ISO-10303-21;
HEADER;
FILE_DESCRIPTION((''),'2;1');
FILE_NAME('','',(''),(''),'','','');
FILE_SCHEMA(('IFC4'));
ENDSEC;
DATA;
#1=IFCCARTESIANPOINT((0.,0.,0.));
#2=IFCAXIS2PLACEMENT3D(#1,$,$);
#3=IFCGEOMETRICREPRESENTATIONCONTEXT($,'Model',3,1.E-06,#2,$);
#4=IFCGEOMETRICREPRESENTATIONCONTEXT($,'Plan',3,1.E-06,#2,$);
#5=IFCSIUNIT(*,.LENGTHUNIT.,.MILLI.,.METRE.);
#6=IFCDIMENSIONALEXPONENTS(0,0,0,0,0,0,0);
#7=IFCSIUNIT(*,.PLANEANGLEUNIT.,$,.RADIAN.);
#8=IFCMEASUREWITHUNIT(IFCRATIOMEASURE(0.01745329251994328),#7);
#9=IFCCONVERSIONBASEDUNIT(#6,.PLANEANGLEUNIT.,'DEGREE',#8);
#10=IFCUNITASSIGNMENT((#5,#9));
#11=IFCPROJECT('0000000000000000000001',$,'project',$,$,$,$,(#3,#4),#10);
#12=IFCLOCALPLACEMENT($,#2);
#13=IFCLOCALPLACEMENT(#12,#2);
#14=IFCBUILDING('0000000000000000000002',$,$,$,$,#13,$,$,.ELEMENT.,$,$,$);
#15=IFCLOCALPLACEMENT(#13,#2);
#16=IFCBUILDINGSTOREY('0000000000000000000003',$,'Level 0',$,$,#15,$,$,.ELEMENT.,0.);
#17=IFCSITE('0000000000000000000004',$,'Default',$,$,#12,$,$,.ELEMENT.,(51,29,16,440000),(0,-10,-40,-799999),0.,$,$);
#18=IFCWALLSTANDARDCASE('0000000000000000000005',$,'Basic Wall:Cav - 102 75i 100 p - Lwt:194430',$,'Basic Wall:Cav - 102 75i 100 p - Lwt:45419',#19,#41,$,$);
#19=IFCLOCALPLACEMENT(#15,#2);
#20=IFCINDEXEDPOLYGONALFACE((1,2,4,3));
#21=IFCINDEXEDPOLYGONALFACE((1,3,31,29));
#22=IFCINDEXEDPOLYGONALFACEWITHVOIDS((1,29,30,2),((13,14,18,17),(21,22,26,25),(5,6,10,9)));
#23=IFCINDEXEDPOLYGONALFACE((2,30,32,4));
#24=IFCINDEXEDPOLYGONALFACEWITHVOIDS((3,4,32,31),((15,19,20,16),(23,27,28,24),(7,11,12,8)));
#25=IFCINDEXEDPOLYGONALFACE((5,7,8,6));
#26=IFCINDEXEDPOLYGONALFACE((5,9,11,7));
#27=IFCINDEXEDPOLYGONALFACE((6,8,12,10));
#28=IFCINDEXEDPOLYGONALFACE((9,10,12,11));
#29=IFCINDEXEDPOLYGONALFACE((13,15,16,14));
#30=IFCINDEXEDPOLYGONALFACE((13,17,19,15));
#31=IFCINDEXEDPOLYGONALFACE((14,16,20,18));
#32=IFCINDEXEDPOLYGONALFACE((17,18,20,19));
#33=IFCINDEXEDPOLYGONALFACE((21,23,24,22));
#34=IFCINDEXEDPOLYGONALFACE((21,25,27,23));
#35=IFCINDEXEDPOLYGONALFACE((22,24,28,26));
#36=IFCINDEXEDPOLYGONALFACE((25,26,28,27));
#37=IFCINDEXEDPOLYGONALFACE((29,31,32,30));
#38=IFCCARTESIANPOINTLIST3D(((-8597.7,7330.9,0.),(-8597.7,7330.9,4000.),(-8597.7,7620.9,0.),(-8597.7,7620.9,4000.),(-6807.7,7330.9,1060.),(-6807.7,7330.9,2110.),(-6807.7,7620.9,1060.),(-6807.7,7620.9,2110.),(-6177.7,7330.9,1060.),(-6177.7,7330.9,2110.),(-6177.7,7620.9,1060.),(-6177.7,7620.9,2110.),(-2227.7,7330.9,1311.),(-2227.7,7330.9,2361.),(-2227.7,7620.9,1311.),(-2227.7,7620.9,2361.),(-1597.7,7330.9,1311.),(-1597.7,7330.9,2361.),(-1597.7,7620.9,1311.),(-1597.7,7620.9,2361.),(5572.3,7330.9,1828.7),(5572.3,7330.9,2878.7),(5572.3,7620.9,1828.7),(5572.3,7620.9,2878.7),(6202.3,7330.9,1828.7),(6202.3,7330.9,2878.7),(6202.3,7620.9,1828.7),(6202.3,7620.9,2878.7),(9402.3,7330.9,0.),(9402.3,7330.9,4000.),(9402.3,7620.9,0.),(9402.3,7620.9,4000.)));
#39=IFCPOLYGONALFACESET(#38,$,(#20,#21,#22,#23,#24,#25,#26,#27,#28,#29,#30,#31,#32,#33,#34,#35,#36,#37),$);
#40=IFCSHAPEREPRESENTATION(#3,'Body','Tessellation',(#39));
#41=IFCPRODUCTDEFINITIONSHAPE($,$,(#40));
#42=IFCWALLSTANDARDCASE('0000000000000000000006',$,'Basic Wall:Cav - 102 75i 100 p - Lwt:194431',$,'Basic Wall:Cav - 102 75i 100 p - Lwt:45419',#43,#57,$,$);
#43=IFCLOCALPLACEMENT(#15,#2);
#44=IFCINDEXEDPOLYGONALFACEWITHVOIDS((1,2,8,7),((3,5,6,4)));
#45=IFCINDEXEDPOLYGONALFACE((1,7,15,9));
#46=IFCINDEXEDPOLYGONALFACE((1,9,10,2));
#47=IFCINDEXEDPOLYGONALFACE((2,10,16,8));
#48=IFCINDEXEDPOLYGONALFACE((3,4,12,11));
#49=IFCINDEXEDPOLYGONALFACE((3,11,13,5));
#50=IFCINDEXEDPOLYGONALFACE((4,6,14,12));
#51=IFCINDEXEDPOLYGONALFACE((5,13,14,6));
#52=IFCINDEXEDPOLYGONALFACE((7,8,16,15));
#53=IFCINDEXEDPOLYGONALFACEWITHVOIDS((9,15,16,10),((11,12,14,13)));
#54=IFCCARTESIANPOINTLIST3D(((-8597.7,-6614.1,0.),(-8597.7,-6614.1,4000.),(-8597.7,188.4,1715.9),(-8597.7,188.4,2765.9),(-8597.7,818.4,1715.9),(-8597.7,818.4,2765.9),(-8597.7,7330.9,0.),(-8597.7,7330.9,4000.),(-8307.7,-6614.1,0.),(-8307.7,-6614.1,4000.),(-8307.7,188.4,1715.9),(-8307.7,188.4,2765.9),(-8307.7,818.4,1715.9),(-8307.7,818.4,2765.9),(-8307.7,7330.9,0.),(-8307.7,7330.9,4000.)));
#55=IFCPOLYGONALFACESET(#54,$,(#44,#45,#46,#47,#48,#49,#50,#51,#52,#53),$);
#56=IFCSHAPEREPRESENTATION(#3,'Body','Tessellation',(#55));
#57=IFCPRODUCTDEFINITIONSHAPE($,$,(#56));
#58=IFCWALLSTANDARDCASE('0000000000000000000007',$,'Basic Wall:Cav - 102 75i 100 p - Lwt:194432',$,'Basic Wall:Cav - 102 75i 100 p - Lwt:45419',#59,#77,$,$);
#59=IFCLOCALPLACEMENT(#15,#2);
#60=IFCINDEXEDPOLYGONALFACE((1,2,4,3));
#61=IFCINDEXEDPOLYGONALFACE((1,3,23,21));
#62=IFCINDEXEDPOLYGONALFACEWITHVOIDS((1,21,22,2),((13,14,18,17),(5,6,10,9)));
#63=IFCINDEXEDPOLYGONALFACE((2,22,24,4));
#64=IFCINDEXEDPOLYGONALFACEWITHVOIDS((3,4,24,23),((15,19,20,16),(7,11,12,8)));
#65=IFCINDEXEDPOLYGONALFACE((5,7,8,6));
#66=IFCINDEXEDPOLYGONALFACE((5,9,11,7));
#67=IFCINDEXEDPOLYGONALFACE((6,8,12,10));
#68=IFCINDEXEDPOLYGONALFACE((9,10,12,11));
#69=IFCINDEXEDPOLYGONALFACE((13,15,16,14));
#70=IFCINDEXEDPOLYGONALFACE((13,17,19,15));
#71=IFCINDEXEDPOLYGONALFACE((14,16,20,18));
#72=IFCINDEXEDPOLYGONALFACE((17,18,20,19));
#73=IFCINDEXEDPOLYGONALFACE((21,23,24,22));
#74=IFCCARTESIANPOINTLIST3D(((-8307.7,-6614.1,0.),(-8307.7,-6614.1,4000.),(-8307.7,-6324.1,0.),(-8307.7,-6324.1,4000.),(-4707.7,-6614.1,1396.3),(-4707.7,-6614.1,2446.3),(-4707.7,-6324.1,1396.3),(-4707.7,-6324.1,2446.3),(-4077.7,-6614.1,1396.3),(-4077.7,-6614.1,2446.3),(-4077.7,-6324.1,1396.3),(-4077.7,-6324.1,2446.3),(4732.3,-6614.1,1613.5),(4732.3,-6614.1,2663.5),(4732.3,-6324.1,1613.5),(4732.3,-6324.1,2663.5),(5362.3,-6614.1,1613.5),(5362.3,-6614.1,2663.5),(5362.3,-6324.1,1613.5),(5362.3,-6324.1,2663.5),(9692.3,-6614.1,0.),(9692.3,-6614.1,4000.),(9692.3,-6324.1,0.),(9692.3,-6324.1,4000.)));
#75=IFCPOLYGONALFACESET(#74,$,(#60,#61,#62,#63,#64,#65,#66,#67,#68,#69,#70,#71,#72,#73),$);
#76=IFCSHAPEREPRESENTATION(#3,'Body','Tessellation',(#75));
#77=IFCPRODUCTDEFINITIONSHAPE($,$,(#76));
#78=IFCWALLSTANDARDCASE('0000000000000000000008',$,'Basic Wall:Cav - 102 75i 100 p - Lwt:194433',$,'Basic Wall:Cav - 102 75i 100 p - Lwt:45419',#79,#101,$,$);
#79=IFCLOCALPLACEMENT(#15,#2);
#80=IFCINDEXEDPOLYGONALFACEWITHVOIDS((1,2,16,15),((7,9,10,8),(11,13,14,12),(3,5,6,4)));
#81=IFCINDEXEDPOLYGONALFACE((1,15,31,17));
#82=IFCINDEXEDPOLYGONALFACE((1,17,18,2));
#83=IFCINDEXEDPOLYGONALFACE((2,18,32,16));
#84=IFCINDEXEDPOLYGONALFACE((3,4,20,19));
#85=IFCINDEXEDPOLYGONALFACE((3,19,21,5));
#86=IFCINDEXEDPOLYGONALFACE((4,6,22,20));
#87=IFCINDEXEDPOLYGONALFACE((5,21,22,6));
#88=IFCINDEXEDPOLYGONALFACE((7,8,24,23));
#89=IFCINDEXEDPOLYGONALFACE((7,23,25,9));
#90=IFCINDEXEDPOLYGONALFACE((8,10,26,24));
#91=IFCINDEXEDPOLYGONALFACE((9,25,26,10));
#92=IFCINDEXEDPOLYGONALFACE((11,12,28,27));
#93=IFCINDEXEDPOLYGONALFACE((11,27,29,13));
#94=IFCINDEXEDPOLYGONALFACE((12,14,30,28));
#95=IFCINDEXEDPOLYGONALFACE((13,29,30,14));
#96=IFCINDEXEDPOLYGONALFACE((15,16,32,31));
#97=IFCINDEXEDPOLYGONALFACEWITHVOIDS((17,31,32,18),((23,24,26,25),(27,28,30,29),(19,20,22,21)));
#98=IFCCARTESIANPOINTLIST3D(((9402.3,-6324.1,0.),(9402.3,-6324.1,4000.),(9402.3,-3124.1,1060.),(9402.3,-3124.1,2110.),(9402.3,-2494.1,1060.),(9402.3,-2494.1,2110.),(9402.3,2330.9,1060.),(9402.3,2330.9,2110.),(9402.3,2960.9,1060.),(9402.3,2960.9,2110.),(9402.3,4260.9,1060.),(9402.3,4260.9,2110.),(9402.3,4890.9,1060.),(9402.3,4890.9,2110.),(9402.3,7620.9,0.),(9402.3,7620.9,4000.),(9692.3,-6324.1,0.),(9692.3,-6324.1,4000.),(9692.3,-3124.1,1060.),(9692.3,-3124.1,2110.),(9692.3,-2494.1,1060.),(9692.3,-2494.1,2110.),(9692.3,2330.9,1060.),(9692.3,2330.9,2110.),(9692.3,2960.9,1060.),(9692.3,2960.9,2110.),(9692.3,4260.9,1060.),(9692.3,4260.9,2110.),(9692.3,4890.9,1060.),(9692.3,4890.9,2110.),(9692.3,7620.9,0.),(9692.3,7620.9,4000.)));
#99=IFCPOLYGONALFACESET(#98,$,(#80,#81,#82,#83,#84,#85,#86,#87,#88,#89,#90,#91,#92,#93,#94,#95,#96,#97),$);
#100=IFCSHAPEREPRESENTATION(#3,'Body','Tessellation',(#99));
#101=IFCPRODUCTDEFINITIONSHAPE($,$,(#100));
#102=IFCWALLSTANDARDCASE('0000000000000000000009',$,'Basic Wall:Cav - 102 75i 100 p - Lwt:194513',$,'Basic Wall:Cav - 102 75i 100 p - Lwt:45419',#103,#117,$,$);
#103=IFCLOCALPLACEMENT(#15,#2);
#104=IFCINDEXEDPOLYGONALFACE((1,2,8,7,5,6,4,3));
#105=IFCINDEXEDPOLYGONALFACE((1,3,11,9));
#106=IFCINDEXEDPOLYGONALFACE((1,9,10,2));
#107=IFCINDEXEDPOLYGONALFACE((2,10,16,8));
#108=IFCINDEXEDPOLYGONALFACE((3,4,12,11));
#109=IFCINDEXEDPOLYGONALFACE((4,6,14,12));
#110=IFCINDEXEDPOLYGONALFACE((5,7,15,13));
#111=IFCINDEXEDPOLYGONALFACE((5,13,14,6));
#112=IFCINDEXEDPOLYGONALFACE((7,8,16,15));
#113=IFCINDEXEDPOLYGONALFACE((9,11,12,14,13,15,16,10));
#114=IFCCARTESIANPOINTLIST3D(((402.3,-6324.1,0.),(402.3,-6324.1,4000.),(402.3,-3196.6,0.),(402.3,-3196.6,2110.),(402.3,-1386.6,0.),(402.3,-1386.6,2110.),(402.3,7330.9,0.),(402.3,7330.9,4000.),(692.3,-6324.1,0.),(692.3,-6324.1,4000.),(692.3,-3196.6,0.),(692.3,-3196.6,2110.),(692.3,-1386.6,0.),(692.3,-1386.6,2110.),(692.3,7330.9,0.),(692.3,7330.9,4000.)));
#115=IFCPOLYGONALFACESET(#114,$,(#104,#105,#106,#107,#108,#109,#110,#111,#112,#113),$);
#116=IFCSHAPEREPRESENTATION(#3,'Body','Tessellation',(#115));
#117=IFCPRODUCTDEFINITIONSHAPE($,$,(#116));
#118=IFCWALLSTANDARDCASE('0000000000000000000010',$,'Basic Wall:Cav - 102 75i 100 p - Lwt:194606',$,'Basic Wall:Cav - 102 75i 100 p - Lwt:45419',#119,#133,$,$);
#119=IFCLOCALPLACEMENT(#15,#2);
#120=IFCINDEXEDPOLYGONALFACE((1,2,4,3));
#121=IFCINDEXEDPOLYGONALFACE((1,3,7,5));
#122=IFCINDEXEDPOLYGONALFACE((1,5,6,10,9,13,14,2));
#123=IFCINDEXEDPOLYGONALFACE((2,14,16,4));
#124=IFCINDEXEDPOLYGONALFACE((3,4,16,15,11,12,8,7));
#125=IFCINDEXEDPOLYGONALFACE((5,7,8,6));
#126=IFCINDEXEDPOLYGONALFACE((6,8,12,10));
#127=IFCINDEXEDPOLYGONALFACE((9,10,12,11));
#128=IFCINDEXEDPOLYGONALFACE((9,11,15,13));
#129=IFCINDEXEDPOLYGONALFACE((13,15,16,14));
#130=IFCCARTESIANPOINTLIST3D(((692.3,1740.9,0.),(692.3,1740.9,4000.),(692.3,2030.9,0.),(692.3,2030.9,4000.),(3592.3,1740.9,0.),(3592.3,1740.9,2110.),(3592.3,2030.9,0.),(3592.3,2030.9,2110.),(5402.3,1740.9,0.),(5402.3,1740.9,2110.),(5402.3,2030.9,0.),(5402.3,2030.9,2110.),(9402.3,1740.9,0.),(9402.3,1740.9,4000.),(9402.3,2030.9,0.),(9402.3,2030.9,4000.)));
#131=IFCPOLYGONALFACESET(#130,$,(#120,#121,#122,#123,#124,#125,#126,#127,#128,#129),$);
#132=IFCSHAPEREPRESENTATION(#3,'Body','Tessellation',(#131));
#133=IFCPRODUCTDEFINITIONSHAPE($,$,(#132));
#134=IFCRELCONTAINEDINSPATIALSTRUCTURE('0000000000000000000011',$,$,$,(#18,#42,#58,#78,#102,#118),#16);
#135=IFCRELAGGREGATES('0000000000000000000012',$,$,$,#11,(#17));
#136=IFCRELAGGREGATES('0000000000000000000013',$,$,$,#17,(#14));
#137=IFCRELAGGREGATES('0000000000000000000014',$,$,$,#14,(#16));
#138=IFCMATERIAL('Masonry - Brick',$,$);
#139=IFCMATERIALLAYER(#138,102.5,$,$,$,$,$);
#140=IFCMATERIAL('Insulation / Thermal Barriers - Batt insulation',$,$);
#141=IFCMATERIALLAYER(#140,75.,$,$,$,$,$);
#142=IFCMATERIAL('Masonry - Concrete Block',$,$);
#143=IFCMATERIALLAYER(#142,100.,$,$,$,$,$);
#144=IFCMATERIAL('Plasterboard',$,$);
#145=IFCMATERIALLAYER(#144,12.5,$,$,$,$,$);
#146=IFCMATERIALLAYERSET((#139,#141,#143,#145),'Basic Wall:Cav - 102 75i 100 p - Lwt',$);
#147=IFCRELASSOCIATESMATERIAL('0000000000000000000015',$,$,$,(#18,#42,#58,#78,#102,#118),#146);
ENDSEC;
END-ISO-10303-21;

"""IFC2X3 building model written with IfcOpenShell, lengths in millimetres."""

from ifc_helpers import new_model, entity, si_unit, converted_unit, frame, frame_2d, origin, place, context, project, spatial, rectangle, extrude, material, layer, layer_set, layer_usage, element, save


model = new_model("IFC2X3")

# Units and contexts
model_context = context("Model", 3, precision=1e-06, world=origin())
plan_context = context("Plan", 3, precision=1e-06, world=origin())
ifc_project = project(units=[si_unit("LENGTHUNIT", "METRE", prefix="MILLI"), converted_unit("PLANEANGLEUNIT", "DEGREE", entity("IfcRatioMeasure", 0.01745329251994328), si_unit("PLANEANGLEUNIT", "RADIAN"), dimensions=[0, 0, 0, 0, 0, 0, 0])], contexts=[model_context, plan_context])

# Site, building, storey
site_placement = place(None, origin())
site = spatial("IfcSite", under=ifc_project, at=site_placement, Name="Default", CompositionType="ELEMENT", RefLatitude=(51, 29, 16, 440000), RefLongitude=(0, -10, -40, -799999), RefElevation=0.0)
building_placement = place(site_placement, origin())
building = spatial("IfcBuilding", under=site, at=building_placement, CompositionType="ELEMENT")
storey_placement = place(building_placement, origin())
storey = spatial("IfcBuildingStorey", under=building, at=storey_placement, Name="Level 0", CompositionType="ELEMENT", Elevation=0.0)

# Wall, openings
ifc_material_1 = material(Name="Masonry - Brick")
ifc_layer_1 = layer(ifc_material_1, 102.5)
ifc_material_2 = material(Name="Insulation / Thermal Barriers - Batt insulation")
ifc_layer_2 = layer(ifc_material_2, 75.0)
ifc_material_3 = material(Name="Masonry - Concrete Block")
ifc_layer_3 = layer(ifc_material_3, 100.0)
ifc_material_4 = material(Name="Plasterboard")
ifc_layer_4 = layer(ifc_material_4, 12.5)
ifc_layer_set = layer_set([ifc_layer_1, ifc_layer_2, ifc_layer_3, ifc_layer_4], Name="Basic Wall:Cav - 102 75i 100 p - Lwt")
ifc_layer_usage_1 = layer_usage(ifc_layer_set, "AXIS2", "NEGATIVE", 145.0)
wall_1_placement = place(storey_placement, frame((-8597.7, 7475.9, 0.0)))
wall_1 = element("IfcWallStandardCase", 1, at=wall_1_placement, inside=storey, material=ifc_layer_usage_1, Name="Basic Wall:Cav - 102 75i 100 p - Lwt:194430", ObjectType="Basic Wall:Cav - 102 75i 100 p - Lwt:45419", context=model_context, shape_type="SweptSolid", body=[
    extrude(rectangle(XDim=18000.0, YDim=290.0, at=frame_2d((9000.0, 0.0), x_axis=(-1.0, 0.0))), origin(), (0.0, 0.0, 1.0), 4000.0),
])
opening_1_placement = place(wall_1_placement, frame((14170.0, -145.0, 1828.7)))
element("IfcOpeningElement", 2, at=opening_1_placement, cuts=wall_1, ObjectType="Opening", context=model_context, shape_type="SweptSolid", body=[
    extrude(rectangle(XDim=1050.0, YDim=630.0, at=frame_2d((525.0, 315.0), x_axis=(-1.0, 0.0))), frame((0.0, 0.0, 0.0), z_axis=(0.0, 1.0, 0.0), x_axis=(0.0, 0.0, 1.0)), (0.0, 0.0, 1.0), 290.0),
])
opening_2_placement = place(wall_1_placement, frame((6370.0, -145.0, 1311.0)))
element("IfcOpeningElement", 3, at=opening_2_placement, cuts=wall_1, ObjectType="Opening", context=model_context, shape_type="SweptSolid", body=[
    extrude(rectangle(XDim=1050.0, YDim=630.0, at=frame_2d((525.0, 315.0), x_axis=(-1.0, 0.0))), frame((0.0, 0.0, 0.0), z_axis=(0.0, 1.0, 0.0), x_axis=(0.0, 0.0, 1.0)), (0.0, 0.0, 1.0), 290.0),
])
opening_3_placement = place(wall_1_placement, frame((1790.0, -145.0, 1060.0)))
element("IfcOpeningElement", 4, at=opening_3_placement, cuts=wall_1, ObjectType="Opening", context=model_context, shape_type="SweptSolid", body=[
    extrude(rectangle(XDim=1050.0, YDim=630.0, at=frame_2d((525.0, 315.0), x_axis=(-1.0, 0.0))), frame((0.0, 0.0, 0.0), z_axis=(0.0, 1.0, 0.0), x_axis=(0.0, 0.0, 1.0)), (0.0, 0.0, 1.0), 290.0),
])

# Wall, opening
ifc_layer_usage_2 = layer_usage(ifc_layer_set, "AXIS2", "NEGATIVE", 145.0)
wall_2_placement = place(storey_placement, frame((-8452.7, -6614.1, 0.0), z_axis=(0.0, 0.0, 1.0), x_axis=(0.0, 1.0, 0.0)))
wall_2 = element("IfcWallStandardCase", 5, at=wall_2_placement, inside=storey, material=ifc_layer_usage_2, Name="Basic Wall:Cav - 102 75i 100 p - Lwt:194431", ObjectType="Basic Wall:Cav - 102 75i 100 p - Lwt:45419", context=model_context, shape_type="SweptSolid", body=[
    extrude(rectangle(XDim=13945.0, YDim=290.0, at=frame_2d((6972.5, 0.0), x_axis=(-1.0, 0.0))), origin(), (0.0, 0.0, 1.0), 4000.0),
])
opening_4_placement = place(wall_2_placement, frame((7432.5, 145.0, 1715.9)))
element("IfcOpeningElement", 6, at=opening_4_placement, cuts=wall_2, ObjectType="Opening", context=model_context, shape_type="SweptSolid", body=[
    extrude(rectangle(XDim=1050.0, YDim=630.0, at=frame_2d((525.0, 315.0), x_axis=(-1.0, 0.0))), frame((0.0, 0.0, 0.0), z_axis=(0.0, -1.0, 0.0), x_axis=(0.0, 0.0, 1.0)), (0.0, 0.0, 1.0), 290.0),
])

# Walls, openings
ifc_layer_usage_3 = layer_usage(ifc_layer_set, "AXIS2", "NEGATIVE", 145.0)
wall_3_placement = place(storey_placement, frame((9692.3, -6469.1, 0.0), z_axis=(0.0, 0.0, 1.0), x_axis=(-1.0, 0.0, 0.0)))
wall_3 = element("IfcWallStandardCase", 7, at=wall_3_placement, inside=storey, material=ifc_layer_usage_3, Name="Basic Wall:Cav - 102 75i 100 p - Lwt:194432", ObjectType="Basic Wall:Cav - 102 75i 100 p - Lwt:45419", context=model_context, shape_type="SweptSolid", body=[
    extrude(rectangle(XDim=18000.0, YDim=290.0, at=frame_2d((9000.0, 0.0), x_axis=(-1.0, 0.0))), origin(), (0.0, 0.0, 1.0), 4000.0),
])
opening_5_placement = place(wall_3_placement, frame((14400.0, 145.0, 1396.3)))
element("IfcOpeningElement", 8, at=opening_5_placement, cuts=wall_3, ObjectType="Opening", context=model_context, shape_type="SweptSolid", body=[
    extrude(rectangle(XDim=1050.0, YDim=630.0, at=frame_2d((525.0, 315.0), x_axis=(-1.0, 0.0))), frame((0.0, 0.0, 0.0), z_axis=(0.0, -1.0, 0.0), x_axis=(0.0, 0.0, 1.0)), (0.0, 0.0, 1.0), 290.0),
])
opening_6_placement = place(wall_3_placement, frame((4960.0, 145.0, 1613.5)))
element("IfcOpeningElement", 9, at=opening_6_placement, cuts=wall_3, ObjectType="Opening", context=model_context, shape_type="SweptSolid", body=[
    extrude(rectangle(XDim=1050.0, YDim=630.0, at=frame_2d((525.0, 315.0), x_axis=(-1.0, 0.0))), frame((0.0, 0.0, 0.0), z_axis=(0.0, -1.0, 0.0), x_axis=(0.0, 0.0, 1.0)), (0.0, 0.0, 1.0), 290.0),
])
ifc_layer_usage_4 = layer_usage(ifc_layer_set, "AXIS2", "NEGATIVE", 145.0)
wall_4_placement = place(storey_placement, frame((9547.3, 7620.9, 0.0), z_axis=(0.0, 0.0, 1.0), x_axis=(0.0, -1.0, 0.0)))
wall_4 = element("IfcWallStandardCase", 10, at=wall_4_placement, inside=storey, material=ifc_layer_usage_4, Name="Basic Wall:Cav - 102 75i 100 p - Lwt:194433", ObjectType="Basic Wall:Cav - 102 75i 100 p - Lwt:45419", context=model_context, shape_type="SweptSolid", body=[
    extrude(rectangle(XDim=13945.0, YDim=290.0, at=frame_2d((6972.5, 0.0), x_axis=(-1.0, 0.0))), origin(), (0.0, 0.0, 1.0), 4000.0),
])
opening_7_placement = place(wall_4_placement, frame((10115.0, -145.0, 1060.0)))
element("IfcOpeningElement", 11, at=opening_7_placement, cuts=wall_4, ObjectType="Opening", context=model_context, shape_type="SweptSolid", body=[
    extrude(rectangle(XDim=1050.0, YDim=630.0, at=frame_2d((525.0, 315.0), x_axis=(-1.0, 0.0))), frame((0.0, 0.0, 0.0), z_axis=(0.0, 1.0, 0.0), x_axis=(0.0, 0.0, 1.0)), (0.0, 0.0, 1.0), 290.0),
])
opening_8_placement = place(wall_4_placement, frame((4660.0, -145.0, 1060.0)))
element("IfcOpeningElement", 12, at=opening_8_placement, cuts=wall_4, ObjectType="Opening", context=model_context, shape_type="SweptSolid", body=[
    extrude(rectangle(XDim=1050.0, YDim=630.0, at=frame_2d((525.0, 315.0), x_axis=(-1.0, 0.0))), frame((0.0, 0.0, 0.0), z_axis=(0.0, 1.0, 0.0), x_axis=(0.0, 0.0, 1.0)), (0.0, 0.0, 1.0), 290.0),
])
opening_9_placement = place(wall_4_placement, frame((2730.0, -145.0, 1060.0)))
element("IfcOpeningElement", 13, at=opening_9_placement, cuts=wall_4, ObjectType="Opening", context=model_context, shape_type="SweptSolid", body=[
    extrude(rectangle(XDim=1050.0, YDim=630.0, at=frame_2d((525.0, 315.0), x_axis=(-1.0, 0.0))), frame((0.0, 0.0, 0.0), z_axis=(0.0, 1.0, 0.0), x_axis=(0.0, 0.0, 1.0)), (0.0, 0.0, 1.0), 290.0),
])

# Walls, openings
ifc_layer_usage_5 = layer_usage(ifc_layer_set, "AXIS2", "NEGATIVE", 145.0)
wall_5_placement = place(storey_placement, frame((547.3, 7330.9, 0.0), z_axis=(0.0, 0.0, 1.0), x_axis=(0.0, -1.0, 0.0)))
wall_5 = element("IfcWallStandardCase", 14, at=wall_5_placement, inside=storey, material=ifc_layer_usage_5, Name="Basic Wall:Cav - 102 75i 100 p - Lwt:194513", ObjectType="Basic Wall:Cav - 102 75i 100 p - Lwt:45419", context=model_context, shape_type="SweptSolid", body=[
    extrude(rectangle(XDim=13655.0, YDim=290.0, at=frame_2d((6827.5, 0.0), x_axis=(-1.0, 0.0))), origin(), (0.0, 0.0, 1.0), 4000.0),
])
opening_10_placement = place(wall_5_placement, frame((10527.5, 145.0, 0.0)))
element("IfcOpeningElement", 15, at=opening_10_placement, cuts=wall_5, ObjectType="Opening", context=model_context, shape_type="SweptSolid", body=[
    extrude(rectangle(XDim=2110.0, YDim=1810.0, at=frame_2d((1055.0, 905.0), x_axis=(-1.0, 0.0))), frame((0.0, 0.0, 0.0), z_axis=(0.0, -1.0, 0.0), x_axis=(0.0, 0.0, 1.0)), (0.0, 0.0, 1.0), 290.0),
])
ifc_layer_usage_6 = layer_usage(ifc_layer_set, "AXIS2", "NEGATIVE", 145.0)
wall_6_placement = place(storey_placement, frame((692.3, 1885.9, 0.0)))
wall_6 = element("IfcWallStandardCase", 16, at=wall_6_placement, inside=storey, material=ifc_layer_usage_6, Name="Basic Wall:Cav - 102 75i 100 p - Lwt:194606", ObjectType="Basic Wall:Cav - 102 75i 100 p - Lwt:45419", context=model_context, shape_type="SweptSolid", body=[
    extrude(rectangle(XDim=8710.0, YDim=290.0, at=frame_2d((4355.0, 0.0), x_axis=(-1.0, 0.0))), origin(), (0.0, 0.0, 1.0), 4000.0),
])
opening_11_placement = place(wall_6_placement, frame((2900.0, -145.0, 0.0)))
element("IfcOpeningElement", 17, at=opening_11_placement, cuts=wall_6, ObjectType="Opening", context=model_context, shape_type="SweptSolid", body=[
    extrude(rectangle(XDim=2110.0, YDim=1810.0, at=frame_2d((1055.0, 905.0), x_axis=(-1.0, 0.0))), frame((0.0, 0.0, 0.0), z_axis=(0.0, 1.0, 0.0), x_axis=(0.0, 0.0, 1.0)), (0.0, 0.0, 1.0), 290.0),
])

save(model, "model.ifc")
